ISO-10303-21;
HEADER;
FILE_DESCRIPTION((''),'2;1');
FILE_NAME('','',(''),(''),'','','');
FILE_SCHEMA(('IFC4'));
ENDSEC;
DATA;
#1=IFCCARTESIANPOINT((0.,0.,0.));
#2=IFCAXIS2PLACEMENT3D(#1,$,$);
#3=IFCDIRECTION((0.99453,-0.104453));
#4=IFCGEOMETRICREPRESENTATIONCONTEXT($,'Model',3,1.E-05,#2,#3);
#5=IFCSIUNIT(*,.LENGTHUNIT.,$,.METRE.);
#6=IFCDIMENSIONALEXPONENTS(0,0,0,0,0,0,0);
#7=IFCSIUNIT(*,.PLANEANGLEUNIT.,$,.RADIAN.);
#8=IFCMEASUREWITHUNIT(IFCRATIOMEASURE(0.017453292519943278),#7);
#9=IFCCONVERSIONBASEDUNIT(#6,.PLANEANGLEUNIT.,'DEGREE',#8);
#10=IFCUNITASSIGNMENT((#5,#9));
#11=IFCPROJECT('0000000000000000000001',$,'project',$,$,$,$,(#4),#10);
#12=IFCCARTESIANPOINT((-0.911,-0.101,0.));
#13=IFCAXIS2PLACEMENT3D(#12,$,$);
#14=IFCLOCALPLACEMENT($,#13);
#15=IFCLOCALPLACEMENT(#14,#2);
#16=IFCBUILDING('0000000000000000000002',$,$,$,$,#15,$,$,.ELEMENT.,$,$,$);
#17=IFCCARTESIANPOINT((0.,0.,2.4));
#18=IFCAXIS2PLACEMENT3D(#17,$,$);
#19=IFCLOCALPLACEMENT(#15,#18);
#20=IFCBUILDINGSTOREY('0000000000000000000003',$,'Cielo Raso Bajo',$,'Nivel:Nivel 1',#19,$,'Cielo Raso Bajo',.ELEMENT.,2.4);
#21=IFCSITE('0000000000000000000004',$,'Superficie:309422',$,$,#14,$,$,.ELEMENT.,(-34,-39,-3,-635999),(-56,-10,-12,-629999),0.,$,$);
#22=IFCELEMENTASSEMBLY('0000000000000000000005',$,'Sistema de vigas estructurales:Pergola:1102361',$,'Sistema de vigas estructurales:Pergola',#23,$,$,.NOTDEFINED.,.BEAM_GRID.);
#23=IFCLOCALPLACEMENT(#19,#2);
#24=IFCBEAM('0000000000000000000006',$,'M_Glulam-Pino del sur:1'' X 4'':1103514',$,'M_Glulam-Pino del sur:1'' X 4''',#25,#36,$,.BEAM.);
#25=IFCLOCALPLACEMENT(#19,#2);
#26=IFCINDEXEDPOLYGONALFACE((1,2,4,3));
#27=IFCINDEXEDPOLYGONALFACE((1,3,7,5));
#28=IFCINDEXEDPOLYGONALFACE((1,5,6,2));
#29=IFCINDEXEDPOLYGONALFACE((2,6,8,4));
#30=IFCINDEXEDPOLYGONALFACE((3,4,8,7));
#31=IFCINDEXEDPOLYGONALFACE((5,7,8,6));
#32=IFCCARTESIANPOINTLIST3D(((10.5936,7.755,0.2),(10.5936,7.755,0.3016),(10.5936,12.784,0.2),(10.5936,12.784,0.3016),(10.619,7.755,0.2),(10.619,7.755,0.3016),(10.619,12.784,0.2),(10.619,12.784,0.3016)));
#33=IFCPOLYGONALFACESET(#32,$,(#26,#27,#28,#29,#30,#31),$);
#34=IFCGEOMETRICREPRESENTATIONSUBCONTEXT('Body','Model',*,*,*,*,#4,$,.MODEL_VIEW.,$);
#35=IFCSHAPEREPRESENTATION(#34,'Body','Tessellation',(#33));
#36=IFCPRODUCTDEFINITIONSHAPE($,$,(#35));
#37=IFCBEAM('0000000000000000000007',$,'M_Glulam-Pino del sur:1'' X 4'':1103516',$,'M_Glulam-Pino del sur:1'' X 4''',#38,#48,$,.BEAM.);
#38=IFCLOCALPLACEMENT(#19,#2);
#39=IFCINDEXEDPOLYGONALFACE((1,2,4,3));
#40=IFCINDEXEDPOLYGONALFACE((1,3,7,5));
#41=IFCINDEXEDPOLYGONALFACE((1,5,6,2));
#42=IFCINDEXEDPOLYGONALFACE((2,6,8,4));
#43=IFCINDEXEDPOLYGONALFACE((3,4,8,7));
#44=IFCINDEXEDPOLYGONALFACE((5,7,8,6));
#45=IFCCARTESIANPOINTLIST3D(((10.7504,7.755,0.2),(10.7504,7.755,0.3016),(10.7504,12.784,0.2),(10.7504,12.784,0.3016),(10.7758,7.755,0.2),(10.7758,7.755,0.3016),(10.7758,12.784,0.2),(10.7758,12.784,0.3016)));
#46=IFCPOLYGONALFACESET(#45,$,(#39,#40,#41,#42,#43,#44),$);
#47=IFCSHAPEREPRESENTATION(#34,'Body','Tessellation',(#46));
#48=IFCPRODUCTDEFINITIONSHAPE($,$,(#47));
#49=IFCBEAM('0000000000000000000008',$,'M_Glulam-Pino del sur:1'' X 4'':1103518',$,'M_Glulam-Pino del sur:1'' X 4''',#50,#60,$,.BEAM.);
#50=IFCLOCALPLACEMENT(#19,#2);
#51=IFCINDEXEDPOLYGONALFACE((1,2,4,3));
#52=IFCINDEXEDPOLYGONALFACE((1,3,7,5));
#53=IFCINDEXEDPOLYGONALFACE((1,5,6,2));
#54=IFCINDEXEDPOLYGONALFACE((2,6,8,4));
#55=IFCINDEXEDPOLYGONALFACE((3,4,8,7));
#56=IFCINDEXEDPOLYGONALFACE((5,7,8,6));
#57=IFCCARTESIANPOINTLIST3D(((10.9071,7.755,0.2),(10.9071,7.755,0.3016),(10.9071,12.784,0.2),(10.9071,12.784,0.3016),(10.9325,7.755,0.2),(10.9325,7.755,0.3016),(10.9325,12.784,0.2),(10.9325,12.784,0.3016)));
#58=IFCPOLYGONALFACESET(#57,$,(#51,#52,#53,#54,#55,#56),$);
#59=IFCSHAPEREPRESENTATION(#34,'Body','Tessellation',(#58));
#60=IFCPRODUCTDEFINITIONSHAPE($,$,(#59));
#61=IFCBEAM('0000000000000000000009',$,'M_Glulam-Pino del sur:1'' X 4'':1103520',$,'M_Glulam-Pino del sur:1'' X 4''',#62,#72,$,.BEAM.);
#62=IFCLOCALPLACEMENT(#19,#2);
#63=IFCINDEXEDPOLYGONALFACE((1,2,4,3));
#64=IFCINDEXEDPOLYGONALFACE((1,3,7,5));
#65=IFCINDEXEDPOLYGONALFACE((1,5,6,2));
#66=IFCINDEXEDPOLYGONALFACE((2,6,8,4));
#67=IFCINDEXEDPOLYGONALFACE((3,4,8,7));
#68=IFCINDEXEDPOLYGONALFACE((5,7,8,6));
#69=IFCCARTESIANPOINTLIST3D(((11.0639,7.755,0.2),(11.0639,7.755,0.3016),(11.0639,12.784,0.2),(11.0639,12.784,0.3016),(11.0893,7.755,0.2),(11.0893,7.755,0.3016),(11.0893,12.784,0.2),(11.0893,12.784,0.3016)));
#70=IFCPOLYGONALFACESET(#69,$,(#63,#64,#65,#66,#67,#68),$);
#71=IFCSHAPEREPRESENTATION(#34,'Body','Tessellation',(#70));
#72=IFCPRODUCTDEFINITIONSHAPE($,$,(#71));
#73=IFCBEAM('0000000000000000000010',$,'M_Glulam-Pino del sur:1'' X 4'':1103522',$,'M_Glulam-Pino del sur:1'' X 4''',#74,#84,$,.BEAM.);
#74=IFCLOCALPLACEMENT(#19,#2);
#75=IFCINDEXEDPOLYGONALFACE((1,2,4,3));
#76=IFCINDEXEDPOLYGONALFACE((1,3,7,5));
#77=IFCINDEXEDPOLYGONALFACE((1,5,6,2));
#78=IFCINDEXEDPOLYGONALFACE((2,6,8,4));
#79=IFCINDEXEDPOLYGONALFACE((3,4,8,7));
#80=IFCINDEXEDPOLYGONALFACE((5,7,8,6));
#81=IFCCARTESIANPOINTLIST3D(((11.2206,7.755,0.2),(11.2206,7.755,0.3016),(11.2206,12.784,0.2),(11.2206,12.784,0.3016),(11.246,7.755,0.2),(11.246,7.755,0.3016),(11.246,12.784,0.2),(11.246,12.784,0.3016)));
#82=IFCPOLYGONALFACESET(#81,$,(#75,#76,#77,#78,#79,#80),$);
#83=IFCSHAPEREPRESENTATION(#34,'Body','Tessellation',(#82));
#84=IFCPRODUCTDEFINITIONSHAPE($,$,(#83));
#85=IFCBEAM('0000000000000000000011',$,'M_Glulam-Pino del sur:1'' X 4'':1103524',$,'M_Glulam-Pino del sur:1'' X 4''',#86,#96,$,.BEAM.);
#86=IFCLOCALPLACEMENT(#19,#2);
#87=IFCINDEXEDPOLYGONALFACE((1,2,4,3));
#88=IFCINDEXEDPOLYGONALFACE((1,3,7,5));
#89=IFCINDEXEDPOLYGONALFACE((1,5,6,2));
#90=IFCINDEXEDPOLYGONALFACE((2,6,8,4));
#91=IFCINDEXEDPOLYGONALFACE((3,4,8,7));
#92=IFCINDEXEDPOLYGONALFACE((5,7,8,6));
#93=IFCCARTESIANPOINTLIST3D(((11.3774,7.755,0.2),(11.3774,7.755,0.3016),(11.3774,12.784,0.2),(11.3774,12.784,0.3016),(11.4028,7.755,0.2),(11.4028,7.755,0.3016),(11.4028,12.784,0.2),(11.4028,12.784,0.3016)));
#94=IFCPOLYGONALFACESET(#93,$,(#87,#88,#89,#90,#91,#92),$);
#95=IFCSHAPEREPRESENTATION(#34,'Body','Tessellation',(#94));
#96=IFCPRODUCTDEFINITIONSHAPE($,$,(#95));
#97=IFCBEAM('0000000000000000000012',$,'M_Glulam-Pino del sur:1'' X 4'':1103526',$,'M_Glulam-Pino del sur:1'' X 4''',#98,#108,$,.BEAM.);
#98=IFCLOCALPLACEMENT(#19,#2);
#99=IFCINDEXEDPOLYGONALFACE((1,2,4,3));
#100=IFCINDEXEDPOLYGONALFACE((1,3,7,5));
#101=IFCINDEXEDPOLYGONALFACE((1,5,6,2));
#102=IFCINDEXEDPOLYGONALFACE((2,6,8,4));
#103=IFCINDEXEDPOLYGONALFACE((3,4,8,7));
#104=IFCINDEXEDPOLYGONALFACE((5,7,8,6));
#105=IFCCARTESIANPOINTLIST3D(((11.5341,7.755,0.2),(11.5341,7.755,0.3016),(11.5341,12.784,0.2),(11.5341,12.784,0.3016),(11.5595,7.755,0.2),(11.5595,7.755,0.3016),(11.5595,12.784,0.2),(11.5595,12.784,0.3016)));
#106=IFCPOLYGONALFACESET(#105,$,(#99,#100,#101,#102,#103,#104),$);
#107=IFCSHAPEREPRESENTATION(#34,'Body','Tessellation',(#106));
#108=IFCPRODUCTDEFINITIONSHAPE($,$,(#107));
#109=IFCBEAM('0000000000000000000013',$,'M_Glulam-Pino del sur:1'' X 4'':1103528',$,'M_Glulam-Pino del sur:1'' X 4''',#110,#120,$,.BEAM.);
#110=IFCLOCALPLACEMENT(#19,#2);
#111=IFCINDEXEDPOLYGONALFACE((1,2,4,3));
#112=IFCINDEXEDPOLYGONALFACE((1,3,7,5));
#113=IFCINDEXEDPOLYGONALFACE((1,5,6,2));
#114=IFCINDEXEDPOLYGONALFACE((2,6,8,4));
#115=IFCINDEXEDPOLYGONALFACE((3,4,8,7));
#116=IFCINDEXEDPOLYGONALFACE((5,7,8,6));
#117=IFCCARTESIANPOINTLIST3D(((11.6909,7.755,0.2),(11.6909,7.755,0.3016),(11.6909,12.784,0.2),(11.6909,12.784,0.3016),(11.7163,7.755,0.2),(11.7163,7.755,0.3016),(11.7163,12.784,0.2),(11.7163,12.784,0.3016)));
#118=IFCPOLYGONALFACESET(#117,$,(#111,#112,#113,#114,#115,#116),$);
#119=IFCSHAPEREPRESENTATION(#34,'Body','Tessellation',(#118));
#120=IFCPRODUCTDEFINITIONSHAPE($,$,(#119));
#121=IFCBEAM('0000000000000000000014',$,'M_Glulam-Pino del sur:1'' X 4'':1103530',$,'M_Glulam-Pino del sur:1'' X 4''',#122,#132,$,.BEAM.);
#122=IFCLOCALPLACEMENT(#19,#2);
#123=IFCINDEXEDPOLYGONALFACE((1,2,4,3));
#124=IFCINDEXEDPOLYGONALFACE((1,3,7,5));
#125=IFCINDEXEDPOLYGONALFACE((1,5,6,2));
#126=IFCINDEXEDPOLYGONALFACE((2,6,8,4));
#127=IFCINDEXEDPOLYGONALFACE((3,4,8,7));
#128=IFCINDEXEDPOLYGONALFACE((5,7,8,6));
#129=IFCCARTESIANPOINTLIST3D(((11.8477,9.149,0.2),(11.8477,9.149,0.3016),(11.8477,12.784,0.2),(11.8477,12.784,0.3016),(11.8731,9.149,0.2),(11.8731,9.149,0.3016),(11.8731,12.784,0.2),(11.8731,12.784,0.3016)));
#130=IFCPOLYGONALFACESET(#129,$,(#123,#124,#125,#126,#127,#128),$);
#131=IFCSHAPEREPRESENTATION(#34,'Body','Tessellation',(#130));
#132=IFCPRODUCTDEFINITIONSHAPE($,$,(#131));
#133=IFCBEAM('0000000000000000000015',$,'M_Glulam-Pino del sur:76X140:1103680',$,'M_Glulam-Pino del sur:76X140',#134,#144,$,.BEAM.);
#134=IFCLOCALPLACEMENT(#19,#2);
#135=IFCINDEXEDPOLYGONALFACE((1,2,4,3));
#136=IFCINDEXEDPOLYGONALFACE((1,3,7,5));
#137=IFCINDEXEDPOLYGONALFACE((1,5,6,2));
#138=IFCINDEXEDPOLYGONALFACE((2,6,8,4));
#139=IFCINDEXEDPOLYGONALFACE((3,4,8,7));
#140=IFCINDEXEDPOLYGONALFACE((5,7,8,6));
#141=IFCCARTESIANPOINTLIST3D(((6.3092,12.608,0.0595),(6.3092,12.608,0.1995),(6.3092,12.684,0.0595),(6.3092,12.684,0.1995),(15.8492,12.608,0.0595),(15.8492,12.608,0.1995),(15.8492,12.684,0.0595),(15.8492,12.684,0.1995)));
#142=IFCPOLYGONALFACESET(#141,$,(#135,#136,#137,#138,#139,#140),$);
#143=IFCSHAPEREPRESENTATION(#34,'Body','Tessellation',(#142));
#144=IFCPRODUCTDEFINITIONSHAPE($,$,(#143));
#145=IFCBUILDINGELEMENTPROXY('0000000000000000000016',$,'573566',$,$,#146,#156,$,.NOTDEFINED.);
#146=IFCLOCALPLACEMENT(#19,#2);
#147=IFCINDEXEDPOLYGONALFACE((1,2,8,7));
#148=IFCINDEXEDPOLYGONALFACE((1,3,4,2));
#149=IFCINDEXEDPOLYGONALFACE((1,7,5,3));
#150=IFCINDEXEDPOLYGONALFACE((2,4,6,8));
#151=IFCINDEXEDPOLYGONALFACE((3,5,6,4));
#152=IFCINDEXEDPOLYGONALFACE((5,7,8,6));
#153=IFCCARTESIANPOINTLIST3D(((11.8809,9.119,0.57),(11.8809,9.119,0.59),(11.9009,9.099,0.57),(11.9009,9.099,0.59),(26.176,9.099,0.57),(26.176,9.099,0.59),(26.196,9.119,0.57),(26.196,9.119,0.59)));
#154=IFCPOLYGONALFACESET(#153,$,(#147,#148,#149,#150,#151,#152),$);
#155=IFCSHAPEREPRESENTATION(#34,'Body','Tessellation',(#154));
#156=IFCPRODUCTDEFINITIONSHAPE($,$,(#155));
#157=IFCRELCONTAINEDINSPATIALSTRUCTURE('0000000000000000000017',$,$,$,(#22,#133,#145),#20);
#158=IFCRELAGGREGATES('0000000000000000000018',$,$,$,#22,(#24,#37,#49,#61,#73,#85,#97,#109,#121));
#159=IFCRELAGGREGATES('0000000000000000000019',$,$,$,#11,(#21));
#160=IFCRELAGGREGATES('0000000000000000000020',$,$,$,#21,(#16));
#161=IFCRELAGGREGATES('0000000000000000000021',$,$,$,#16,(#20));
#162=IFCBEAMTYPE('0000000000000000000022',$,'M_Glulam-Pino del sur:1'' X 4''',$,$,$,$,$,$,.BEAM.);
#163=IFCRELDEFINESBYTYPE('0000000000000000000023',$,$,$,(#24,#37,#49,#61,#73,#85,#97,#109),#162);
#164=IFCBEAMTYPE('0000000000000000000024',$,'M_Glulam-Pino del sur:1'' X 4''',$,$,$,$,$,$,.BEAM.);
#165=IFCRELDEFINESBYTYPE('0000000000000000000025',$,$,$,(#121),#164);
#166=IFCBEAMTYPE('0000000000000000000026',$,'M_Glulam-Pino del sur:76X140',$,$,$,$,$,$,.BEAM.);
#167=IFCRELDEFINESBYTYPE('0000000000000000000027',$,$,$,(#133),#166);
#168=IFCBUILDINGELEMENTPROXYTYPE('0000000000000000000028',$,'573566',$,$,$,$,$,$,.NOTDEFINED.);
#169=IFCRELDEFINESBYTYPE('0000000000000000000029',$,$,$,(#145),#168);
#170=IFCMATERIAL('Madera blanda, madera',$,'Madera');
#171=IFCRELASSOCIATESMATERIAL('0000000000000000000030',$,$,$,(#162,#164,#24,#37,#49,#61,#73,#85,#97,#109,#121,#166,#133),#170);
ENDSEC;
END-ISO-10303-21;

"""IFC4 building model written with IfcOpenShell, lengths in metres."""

from ifc_helpers import new_model, entity, si_unit, converted_unit, direction, frame, origin, origin_2d_with_axis, place, context, subcontext, project, spatial, polyline, segment, composite_curve, rectangle, outline, extrude, source, transform, mapped, material, material_profile, profile_set, profile_usage, type_object, type_shapes, element, aggregate, save


model = new_model("IFC4")

# Units and contexts
model_context = context("Model", 3, precision=1e-05, world=origin(), true_north=direction((0.99453, -0.104453)))
body_context = subcontext(model_context, "Body", "Model", "MODEL_VIEW")
ifc_project = project(units=[si_unit("LENGTHUNIT", "METRE"), converted_unit("PLANEANGLEUNIT", "DEGREE", entity("IfcRatioMeasure", 0.017453292519943278), si_unit("PLANEANGLEUNIT", "RADIAN"), dimensions=[0, 0, 0, 0, 0, 0, 0])], contexts=[model_context])

# Site, building, storey
site_placement = place(None, frame((-0.911, -0.101, 0.0)))
site = spatial("IfcSite", under=ifc_project, at=site_placement, Name="Superficie:309422", CompositionType="ELEMENT", RefLatitude=(-34, -39, -3, -635999), RefLongitude=(-56, -10, -12, -629999), RefElevation=0.0)
building_placement = place(site_placement, origin())
building = spatial("IfcBuilding", under=site, at=building_placement, CompositionType="ELEMENT")
storey_placement = place(building_placement, frame((0.0, 0.0, 2.4)))
storey = spatial("IfcBuildingStorey", under=building, at=storey_placement, Name="Cielo Raso Bajo", ObjectType="Nivel:Nivel 1", LongName="Cielo Raso Bajo", CompositionType="ELEMENT", Elevation=2.4)

# Element assembly, beams
assembly_placement = place(storey_placement, origin())
assembly = element("IfcElementAssembly", 1, at=assembly_placement, inside=storey, Name="Sistema de vigas estructurales:Pergola:1102361", ObjectType="Sistema de vigas estructurales:Pergola", AssemblyPlace="NOTDEFINED", PredefinedType="BEAM_GRID")
ifc_material_1 = material(Name="Madera blanda, madera", Category="Madera")
ifc_material_profile_1 = material_profile(ifc_material_1, outline(composite_curve([segment(polyline([(-0.0127, 0.0508, 0.0), (0.0127, 0.0508, 0.0)]), True, "CONTINUOUS"), segment(polyline([(0.0127, 0.0508, 0.0), (0.0127, -0.0508, 0.0)]), True, "CONTINUOUS"), segment(polyline([(0.0127, -0.0508, 0.0), (-0.0127, -0.0508, 0.0)]), True, "CONTINUOUS"), segment(polyline([(-0.0127, -0.0508, 0.0), (-0.0127, 0.0508, 0.0)]), True, "CONTINUOUS")], self_intersect=False), kind="CURVE"), Name="1' X 4'")
ifc_material_profile_2 = material_profile(ifc_material_1, outline(composite_curve([segment(polyline([(2.5145, -0.0127, -0.0508), (2.5145, -0.0127, 0.0508)]), True, "CONTINUOUS"), segment(polyline([(2.5145, -0.0127, 0.0508), (-2.5145, -0.0127, 0.0508)]), True, "CONTINUOUS"), segment(polyline([(-2.5145, -0.0127, 0.0508), (-2.5145, -0.0127, -0.0508)]), True, "CONTINUOUS"), segment(polyline([(-2.5145, -0.0127, -0.0508), (2.5145, -0.0127, -0.0508)]), True, "CONTINUOUS")], self_intersect=False), kind="CURVE"), Name="1' X 4'")
ifc_profile_set_1 = profile_set([ifc_material_profile_1, ifc_material_profile_2], Name="1' X 4'")
beam_type_1 = type_object("IfcBeamType", Name="M_Glulam-Pino del sur:1' X 4'", PredefinedType="BEAM", material=ifc_profile_set_1)
shared_shape_1 = source(origin(), body_context, "Body", "SweptSolid", [
    extrude(rectangle(XDim=0.1016, YDim=0.0254, at=origin_2d_with_axis()), frame((-2.4455, 0.0, 0.0), z_axis=(1.0, 0.0, 0.0), x_axis=(0.0, 0.0, -1.0)), (0.0, 0.0, 1.0), 5.029),
])
type_shapes(beam_type_1, [shared_shape_1])
ifc_profile_usage_1 = profile_usage(ifc_profile_set_1, cardinal=8)
beam_1_placement = place(assembly_placement, frame((10.6063, 10.2005, 0.2508), z_axis=(0.0, 0.0, 1.0), x_axis=(0.0, 1.0, 0.0)))
beam_1 = element("IfcBeam", 2, at=beam_1_placement, type_object=beam_type_1, material=ifc_profile_usage_1, Name="M_Glulam-Pino del sur:1' X 4':1103514", ObjectType="M_Glulam-Pino del sur:1' X 4'", PredefinedType="BEAM", context=body_context, shape_type="MappedRepresentation", body=[
    mapped(shared_shape_1, transform((0.0, 0.0, 0.0), scale=1.0)),
])
ifc_profile_usage_2 = profile_usage(ifc_profile_set_1, cardinal=8)
beam_2_placement = place(assembly_placement, frame((10.7631, 10.2005, 0.2508), z_axis=(0.0, 0.0, 1.0), x_axis=(0.0, 1.0, 0.0)))
beam_2 = element("IfcBeam", 3, at=beam_2_placement, type_object=beam_type_1, material=ifc_profile_usage_2, Name="M_Glulam-Pino del sur:1' X 4':1103516", ObjectType="M_Glulam-Pino del sur:1' X 4'", PredefinedType="BEAM", context=body_context, shape_type="MappedRepresentation", body=[
    mapped(shared_shape_1, transform((0.0, 0.0, 0.0), scale=1.0)),
])
ifc_profile_usage_3 = profile_usage(ifc_profile_set_1, cardinal=8)
beam_3_placement = place(assembly_placement, frame((10.9198, 10.2005, 0.2508), z_axis=(0.0, 0.0, 1.0), x_axis=(0.0, 1.0, 0.0)))
beam_3 = element("IfcBeam", 4, at=beam_3_placement, type_object=beam_type_1, material=ifc_profile_usage_3, Name="M_Glulam-Pino del sur:1' X 4':1103518", ObjectType="M_Glulam-Pino del sur:1' X 4'", PredefinedType="BEAM", context=body_context, shape_type="MappedRepresentation", body=[
    mapped(shared_shape_1, transform((0.0, 0.0, 0.0), scale=1.0)),
])
ifc_profile_usage_4 = profile_usage(ifc_profile_set_1, cardinal=8)
beam_4_placement = place(assembly_placement, frame((11.0766, 10.2005, 0.2508), z_axis=(0.0, 0.0, 1.0), x_axis=(0.0, 1.0, 0.0)))
beam_4 = element("IfcBeam", 5, at=beam_4_placement, type_object=beam_type_1, material=ifc_profile_usage_4, Name="M_Glulam-Pino del sur:1' X 4':1103520", ObjectType="M_Glulam-Pino del sur:1' X 4'", PredefinedType="BEAM", context=body_context, shape_type="MappedRepresentation", body=[
    mapped(shared_shape_1, transform((0.0, 0.0, 0.0), scale=1.0)),
])
ifc_profile_usage_5 = profile_usage(ifc_profile_set_1, cardinal=8)
beam_5_placement = place(assembly_placement, frame((11.2333, 10.2005, 0.2508), z_axis=(0.0, 0.0, 1.0), x_axis=(0.0, 1.0, 0.0)))
beam_5 = element("IfcBeam", 6, at=beam_5_placement, type_object=beam_type_1, material=ifc_profile_usage_5, Name="M_Glulam-Pino del sur:1' X 4':1103522", ObjectType="M_Glulam-Pino del sur:1' X 4'", PredefinedType="BEAM", context=body_context, shape_type="MappedRepresentation", body=[
    mapped(shared_shape_1, transform((0.0, 0.0, 0.0), scale=1.0)),
])
ifc_profile_usage_6 = profile_usage(ifc_profile_set_1, cardinal=8)
beam_6_placement = place(assembly_placement, frame((11.3901, 10.2005, 0.2508), z_axis=(0.0, 0.0, 1.0), x_axis=(0.0, 1.0, 0.0)))
beam_6 = element("IfcBeam", 7, at=beam_6_placement, type_object=beam_type_1, material=ifc_profile_usage_6, Name="M_Glulam-Pino del sur:1' X 4':1103524", ObjectType="M_Glulam-Pino del sur:1' X 4'", PredefinedType="BEAM", context=body_context, shape_type="MappedRepresentation", body=[
    mapped(shared_shape_1, transform((0.0, 0.0, 0.0), scale=1.0)),
])
ifc_profile_usage_7 = profile_usage(ifc_profile_set_1, cardinal=8)
beam_7_placement = place(assembly_placement, frame((11.5468, 10.2005, 0.2508), z_axis=(0.0, 0.0, 1.0), x_axis=(0.0, 1.0, 0.0)))
beam_7 = element("IfcBeam", 8, at=beam_7_placement, type_object=beam_type_1, material=ifc_profile_usage_7, Name="M_Glulam-Pino del sur:1' X 4':1103526", ObjectType="M_Glulam-Pino del sur:1' X 4'", PredefinedType="BEAM", context=body_context, shape_type="MappedRepresentation", body=[
    mapped(shared_shape_1, transform((0.0, 0.0, 0.0), scale=1.0)),
])
ifc_profile_usage_8 = profile_usage(ifc_profile_set_1, cardinal=8)
beam_8_placement = place(assembly_placement, frame((11.7036, 10.2005, 0.2508), z_axis=(0.0, 0.0, 1.0), x_axis=(0.0, 1.0, 0.0)))
beam_8 = element("IfcBeam", 9, at=beam_8_placement, type_object=beam_type_1, material=ifc_profile_usage_8, Name="M_Glulam-Pino del sur:1' X 4':1103528", ObjectType="M_Glulam-Pino del sur:1' X 4'", PredefinedType="BEAM", context=body_context, shape_type="MappedRepresentation", body=[
    mapped(shared_shape_1, transform((0.0, 0.0, 0.0), scale=1.0)),
])
ifc_profile_usage_9 = profile_usage(ifc_profile_set_1, cardinal=8)
beam_type_2 = type_object("IfcBeamType", Name="M_Glulam-Pino del sur:1' X 4'", PredefinedType="BEAM", material=ifc_profile_set_1)
shared_shape_2 = source(origin(), body_context, "Body", "SweptSolid", [
    extrude(rectangle(XDim=0.1016, YDim=0.0254, at=origin_2d_with_axis()), frame((-1.7485, 0.0, 0.0), z_axis=(1.0, 0.0, 0.0), x_axis=(0.0, 0.0, -1.0)), (0.0, 0.0, 1.0), 3.635),
])
type_shapes(beam_type_2, [shared_shape_2])
beam_9_placement = place(assembly_placement, frame((11.8604, 10.8975, 0.2508), z_axis=(0.0, 0.0, 1.0), x_axis=(0.0, 1.0, 0.0)))
beam_9 = element("IfcBeam", 10, at=beam_9_placement, type_object=beam_type_2, material=ifc_profile_usage_9, Name="M_Glulam-Pino del sur:1' X 4':1103530", ObjectType="M_Glulam-Pino del sur:1' X 4'", PredefinedType="BEAM", context=body_context, shape_type="MappedRepresentation", body=[
    mapped(shared_shape_2, transform((0.0, 0.0, 0.0), scale=1.0)),
])
aggregate(assembly, [beam_1, beam_2, beam_3, beam_4, beam_5, beam_6, beam_7, beam_8, beam_9])

# Beam
ifc_material_profile_3 = material_profile(ifc_material_1, outline(composite_curve([segment(polyline([(-0.038, 0.07, 0.0), (0.038, 0.07, 0.0)]), True, "CONTINUOUS"), segment(polyline([(0.038, 0.07, 0.0), (0.038, -0.07, 0.0)]), True, "CONTINUOUS"), segment(polyline([(0.038, -0.07, 0.0), (-0.038, -0.07, 0.0)]), True, "CONTINUOUS"), segment(polyline([(-0.038, -0.07, 0.0), (-0.038, 0.07, 0.0)]), True, "CONTINUOUS")], self_intersect=False), kind="CURVE"), Name="76X140")
ifc_material_profile_4 = material_profile(ifc_material_1, outline(composite_curve([segment(polyline([(-4.7876, 0.038, 0.07), (-4.7876, 0.038, -0.07)]), True, "CONTINUOUS"), segment(polyline([(-4.7876, 0.038, -0.07), (-4.7876, -0.038, -0.07)]), True, "CONTINUOUS"), segment(polyline([(-4.7876, -0.038, -0.07), (-4.7876, -0.038, 0.07)]), True, "CONTINUOUS"), segment(polyline([(-4.7876, -0.038, 0.07), (-4.7876, 0.038, 0.07)]), True, "CONTINUOUS")], self_intersect=False), kind="CURVE"), Name="76X140")
ifc_profile_set_2 = profile_set([ifc_material_profile_3, ifc_material_profile_4], Name="76X140")
ifc_profile_usage_10 = profile_usage(ifc_profile_set_2, cardinal=1)
beam_type_3 = type_object("IfcBeamType", Name="M_Glulam-Pino del sur:76X140", PredefinedType="BEAM", material=ifc_profile_set_2)
shared_shape_3 = source(origin(), body_context, "Body", "SweptSolid", [
    extrude(rectangle(XDim=0.14, YDim=0.076, at=origin_2d_with_axis()), frame((-4.7876, 0.0, 0.0), z_axis=(1.0, 0.0, 0.0), x_axis=(0.0, 0.0, -1.0)), (0.0, 0.0, 1.0), 9.54),
])
type_shapes(beam_type_3, [shared_shape_3])
beam_10_placement = place(storey_placement, frame((11.0616, 12.646, 0.1295), z_axis=(0.0, 0.0, 1.0), x_axis=(-1.0, 0.0, 0.0)))
element("IfcBeam", 11, at=beam_10_placement, inside=storey, type_object=beam_type_3, material=ifc_profile_usage_10, Name="M_Glulam-Pino del sur:76X140:1103680", ObjectType="M_Glulam-Pino del sur:76X140", PredefinedType="BEAM", context=body_context, shape_type="MappedRepresentation", body=[
    mapped(shared_shape_3, transform((0.0, 0.0, 0.0), scale=1.0)),
])

# Building element proxy
building_element_proxy_type_1 = type_object("IfcBuildingElementProxyType", Name="573566", PredefinedType="NOTDEFINED")
proxy_1_placement = place(storey_placement, frame((11.8809, 9.099, 0.57)))
element("IfcBuildingElementProxy", 12, at=proxy_1_placement, inside=storey, type_object=building_element_proxy_type_1, Name="573566", PredefinedType="NOTDEFINED", context=body_context, shape_type="SweptSolid", body=[
    extrude(outline(polyline([(-7.1375, -0.01), (7.1375, -0.01), (7.1575, 0.01), (-7.1575, 0.01), (-7.1375, -0.01)])), frame((7.1575, 0.01, 0.0)), (0.0, 0.0, 1.0), 0.02),
])

save(model, "model.ifc")
